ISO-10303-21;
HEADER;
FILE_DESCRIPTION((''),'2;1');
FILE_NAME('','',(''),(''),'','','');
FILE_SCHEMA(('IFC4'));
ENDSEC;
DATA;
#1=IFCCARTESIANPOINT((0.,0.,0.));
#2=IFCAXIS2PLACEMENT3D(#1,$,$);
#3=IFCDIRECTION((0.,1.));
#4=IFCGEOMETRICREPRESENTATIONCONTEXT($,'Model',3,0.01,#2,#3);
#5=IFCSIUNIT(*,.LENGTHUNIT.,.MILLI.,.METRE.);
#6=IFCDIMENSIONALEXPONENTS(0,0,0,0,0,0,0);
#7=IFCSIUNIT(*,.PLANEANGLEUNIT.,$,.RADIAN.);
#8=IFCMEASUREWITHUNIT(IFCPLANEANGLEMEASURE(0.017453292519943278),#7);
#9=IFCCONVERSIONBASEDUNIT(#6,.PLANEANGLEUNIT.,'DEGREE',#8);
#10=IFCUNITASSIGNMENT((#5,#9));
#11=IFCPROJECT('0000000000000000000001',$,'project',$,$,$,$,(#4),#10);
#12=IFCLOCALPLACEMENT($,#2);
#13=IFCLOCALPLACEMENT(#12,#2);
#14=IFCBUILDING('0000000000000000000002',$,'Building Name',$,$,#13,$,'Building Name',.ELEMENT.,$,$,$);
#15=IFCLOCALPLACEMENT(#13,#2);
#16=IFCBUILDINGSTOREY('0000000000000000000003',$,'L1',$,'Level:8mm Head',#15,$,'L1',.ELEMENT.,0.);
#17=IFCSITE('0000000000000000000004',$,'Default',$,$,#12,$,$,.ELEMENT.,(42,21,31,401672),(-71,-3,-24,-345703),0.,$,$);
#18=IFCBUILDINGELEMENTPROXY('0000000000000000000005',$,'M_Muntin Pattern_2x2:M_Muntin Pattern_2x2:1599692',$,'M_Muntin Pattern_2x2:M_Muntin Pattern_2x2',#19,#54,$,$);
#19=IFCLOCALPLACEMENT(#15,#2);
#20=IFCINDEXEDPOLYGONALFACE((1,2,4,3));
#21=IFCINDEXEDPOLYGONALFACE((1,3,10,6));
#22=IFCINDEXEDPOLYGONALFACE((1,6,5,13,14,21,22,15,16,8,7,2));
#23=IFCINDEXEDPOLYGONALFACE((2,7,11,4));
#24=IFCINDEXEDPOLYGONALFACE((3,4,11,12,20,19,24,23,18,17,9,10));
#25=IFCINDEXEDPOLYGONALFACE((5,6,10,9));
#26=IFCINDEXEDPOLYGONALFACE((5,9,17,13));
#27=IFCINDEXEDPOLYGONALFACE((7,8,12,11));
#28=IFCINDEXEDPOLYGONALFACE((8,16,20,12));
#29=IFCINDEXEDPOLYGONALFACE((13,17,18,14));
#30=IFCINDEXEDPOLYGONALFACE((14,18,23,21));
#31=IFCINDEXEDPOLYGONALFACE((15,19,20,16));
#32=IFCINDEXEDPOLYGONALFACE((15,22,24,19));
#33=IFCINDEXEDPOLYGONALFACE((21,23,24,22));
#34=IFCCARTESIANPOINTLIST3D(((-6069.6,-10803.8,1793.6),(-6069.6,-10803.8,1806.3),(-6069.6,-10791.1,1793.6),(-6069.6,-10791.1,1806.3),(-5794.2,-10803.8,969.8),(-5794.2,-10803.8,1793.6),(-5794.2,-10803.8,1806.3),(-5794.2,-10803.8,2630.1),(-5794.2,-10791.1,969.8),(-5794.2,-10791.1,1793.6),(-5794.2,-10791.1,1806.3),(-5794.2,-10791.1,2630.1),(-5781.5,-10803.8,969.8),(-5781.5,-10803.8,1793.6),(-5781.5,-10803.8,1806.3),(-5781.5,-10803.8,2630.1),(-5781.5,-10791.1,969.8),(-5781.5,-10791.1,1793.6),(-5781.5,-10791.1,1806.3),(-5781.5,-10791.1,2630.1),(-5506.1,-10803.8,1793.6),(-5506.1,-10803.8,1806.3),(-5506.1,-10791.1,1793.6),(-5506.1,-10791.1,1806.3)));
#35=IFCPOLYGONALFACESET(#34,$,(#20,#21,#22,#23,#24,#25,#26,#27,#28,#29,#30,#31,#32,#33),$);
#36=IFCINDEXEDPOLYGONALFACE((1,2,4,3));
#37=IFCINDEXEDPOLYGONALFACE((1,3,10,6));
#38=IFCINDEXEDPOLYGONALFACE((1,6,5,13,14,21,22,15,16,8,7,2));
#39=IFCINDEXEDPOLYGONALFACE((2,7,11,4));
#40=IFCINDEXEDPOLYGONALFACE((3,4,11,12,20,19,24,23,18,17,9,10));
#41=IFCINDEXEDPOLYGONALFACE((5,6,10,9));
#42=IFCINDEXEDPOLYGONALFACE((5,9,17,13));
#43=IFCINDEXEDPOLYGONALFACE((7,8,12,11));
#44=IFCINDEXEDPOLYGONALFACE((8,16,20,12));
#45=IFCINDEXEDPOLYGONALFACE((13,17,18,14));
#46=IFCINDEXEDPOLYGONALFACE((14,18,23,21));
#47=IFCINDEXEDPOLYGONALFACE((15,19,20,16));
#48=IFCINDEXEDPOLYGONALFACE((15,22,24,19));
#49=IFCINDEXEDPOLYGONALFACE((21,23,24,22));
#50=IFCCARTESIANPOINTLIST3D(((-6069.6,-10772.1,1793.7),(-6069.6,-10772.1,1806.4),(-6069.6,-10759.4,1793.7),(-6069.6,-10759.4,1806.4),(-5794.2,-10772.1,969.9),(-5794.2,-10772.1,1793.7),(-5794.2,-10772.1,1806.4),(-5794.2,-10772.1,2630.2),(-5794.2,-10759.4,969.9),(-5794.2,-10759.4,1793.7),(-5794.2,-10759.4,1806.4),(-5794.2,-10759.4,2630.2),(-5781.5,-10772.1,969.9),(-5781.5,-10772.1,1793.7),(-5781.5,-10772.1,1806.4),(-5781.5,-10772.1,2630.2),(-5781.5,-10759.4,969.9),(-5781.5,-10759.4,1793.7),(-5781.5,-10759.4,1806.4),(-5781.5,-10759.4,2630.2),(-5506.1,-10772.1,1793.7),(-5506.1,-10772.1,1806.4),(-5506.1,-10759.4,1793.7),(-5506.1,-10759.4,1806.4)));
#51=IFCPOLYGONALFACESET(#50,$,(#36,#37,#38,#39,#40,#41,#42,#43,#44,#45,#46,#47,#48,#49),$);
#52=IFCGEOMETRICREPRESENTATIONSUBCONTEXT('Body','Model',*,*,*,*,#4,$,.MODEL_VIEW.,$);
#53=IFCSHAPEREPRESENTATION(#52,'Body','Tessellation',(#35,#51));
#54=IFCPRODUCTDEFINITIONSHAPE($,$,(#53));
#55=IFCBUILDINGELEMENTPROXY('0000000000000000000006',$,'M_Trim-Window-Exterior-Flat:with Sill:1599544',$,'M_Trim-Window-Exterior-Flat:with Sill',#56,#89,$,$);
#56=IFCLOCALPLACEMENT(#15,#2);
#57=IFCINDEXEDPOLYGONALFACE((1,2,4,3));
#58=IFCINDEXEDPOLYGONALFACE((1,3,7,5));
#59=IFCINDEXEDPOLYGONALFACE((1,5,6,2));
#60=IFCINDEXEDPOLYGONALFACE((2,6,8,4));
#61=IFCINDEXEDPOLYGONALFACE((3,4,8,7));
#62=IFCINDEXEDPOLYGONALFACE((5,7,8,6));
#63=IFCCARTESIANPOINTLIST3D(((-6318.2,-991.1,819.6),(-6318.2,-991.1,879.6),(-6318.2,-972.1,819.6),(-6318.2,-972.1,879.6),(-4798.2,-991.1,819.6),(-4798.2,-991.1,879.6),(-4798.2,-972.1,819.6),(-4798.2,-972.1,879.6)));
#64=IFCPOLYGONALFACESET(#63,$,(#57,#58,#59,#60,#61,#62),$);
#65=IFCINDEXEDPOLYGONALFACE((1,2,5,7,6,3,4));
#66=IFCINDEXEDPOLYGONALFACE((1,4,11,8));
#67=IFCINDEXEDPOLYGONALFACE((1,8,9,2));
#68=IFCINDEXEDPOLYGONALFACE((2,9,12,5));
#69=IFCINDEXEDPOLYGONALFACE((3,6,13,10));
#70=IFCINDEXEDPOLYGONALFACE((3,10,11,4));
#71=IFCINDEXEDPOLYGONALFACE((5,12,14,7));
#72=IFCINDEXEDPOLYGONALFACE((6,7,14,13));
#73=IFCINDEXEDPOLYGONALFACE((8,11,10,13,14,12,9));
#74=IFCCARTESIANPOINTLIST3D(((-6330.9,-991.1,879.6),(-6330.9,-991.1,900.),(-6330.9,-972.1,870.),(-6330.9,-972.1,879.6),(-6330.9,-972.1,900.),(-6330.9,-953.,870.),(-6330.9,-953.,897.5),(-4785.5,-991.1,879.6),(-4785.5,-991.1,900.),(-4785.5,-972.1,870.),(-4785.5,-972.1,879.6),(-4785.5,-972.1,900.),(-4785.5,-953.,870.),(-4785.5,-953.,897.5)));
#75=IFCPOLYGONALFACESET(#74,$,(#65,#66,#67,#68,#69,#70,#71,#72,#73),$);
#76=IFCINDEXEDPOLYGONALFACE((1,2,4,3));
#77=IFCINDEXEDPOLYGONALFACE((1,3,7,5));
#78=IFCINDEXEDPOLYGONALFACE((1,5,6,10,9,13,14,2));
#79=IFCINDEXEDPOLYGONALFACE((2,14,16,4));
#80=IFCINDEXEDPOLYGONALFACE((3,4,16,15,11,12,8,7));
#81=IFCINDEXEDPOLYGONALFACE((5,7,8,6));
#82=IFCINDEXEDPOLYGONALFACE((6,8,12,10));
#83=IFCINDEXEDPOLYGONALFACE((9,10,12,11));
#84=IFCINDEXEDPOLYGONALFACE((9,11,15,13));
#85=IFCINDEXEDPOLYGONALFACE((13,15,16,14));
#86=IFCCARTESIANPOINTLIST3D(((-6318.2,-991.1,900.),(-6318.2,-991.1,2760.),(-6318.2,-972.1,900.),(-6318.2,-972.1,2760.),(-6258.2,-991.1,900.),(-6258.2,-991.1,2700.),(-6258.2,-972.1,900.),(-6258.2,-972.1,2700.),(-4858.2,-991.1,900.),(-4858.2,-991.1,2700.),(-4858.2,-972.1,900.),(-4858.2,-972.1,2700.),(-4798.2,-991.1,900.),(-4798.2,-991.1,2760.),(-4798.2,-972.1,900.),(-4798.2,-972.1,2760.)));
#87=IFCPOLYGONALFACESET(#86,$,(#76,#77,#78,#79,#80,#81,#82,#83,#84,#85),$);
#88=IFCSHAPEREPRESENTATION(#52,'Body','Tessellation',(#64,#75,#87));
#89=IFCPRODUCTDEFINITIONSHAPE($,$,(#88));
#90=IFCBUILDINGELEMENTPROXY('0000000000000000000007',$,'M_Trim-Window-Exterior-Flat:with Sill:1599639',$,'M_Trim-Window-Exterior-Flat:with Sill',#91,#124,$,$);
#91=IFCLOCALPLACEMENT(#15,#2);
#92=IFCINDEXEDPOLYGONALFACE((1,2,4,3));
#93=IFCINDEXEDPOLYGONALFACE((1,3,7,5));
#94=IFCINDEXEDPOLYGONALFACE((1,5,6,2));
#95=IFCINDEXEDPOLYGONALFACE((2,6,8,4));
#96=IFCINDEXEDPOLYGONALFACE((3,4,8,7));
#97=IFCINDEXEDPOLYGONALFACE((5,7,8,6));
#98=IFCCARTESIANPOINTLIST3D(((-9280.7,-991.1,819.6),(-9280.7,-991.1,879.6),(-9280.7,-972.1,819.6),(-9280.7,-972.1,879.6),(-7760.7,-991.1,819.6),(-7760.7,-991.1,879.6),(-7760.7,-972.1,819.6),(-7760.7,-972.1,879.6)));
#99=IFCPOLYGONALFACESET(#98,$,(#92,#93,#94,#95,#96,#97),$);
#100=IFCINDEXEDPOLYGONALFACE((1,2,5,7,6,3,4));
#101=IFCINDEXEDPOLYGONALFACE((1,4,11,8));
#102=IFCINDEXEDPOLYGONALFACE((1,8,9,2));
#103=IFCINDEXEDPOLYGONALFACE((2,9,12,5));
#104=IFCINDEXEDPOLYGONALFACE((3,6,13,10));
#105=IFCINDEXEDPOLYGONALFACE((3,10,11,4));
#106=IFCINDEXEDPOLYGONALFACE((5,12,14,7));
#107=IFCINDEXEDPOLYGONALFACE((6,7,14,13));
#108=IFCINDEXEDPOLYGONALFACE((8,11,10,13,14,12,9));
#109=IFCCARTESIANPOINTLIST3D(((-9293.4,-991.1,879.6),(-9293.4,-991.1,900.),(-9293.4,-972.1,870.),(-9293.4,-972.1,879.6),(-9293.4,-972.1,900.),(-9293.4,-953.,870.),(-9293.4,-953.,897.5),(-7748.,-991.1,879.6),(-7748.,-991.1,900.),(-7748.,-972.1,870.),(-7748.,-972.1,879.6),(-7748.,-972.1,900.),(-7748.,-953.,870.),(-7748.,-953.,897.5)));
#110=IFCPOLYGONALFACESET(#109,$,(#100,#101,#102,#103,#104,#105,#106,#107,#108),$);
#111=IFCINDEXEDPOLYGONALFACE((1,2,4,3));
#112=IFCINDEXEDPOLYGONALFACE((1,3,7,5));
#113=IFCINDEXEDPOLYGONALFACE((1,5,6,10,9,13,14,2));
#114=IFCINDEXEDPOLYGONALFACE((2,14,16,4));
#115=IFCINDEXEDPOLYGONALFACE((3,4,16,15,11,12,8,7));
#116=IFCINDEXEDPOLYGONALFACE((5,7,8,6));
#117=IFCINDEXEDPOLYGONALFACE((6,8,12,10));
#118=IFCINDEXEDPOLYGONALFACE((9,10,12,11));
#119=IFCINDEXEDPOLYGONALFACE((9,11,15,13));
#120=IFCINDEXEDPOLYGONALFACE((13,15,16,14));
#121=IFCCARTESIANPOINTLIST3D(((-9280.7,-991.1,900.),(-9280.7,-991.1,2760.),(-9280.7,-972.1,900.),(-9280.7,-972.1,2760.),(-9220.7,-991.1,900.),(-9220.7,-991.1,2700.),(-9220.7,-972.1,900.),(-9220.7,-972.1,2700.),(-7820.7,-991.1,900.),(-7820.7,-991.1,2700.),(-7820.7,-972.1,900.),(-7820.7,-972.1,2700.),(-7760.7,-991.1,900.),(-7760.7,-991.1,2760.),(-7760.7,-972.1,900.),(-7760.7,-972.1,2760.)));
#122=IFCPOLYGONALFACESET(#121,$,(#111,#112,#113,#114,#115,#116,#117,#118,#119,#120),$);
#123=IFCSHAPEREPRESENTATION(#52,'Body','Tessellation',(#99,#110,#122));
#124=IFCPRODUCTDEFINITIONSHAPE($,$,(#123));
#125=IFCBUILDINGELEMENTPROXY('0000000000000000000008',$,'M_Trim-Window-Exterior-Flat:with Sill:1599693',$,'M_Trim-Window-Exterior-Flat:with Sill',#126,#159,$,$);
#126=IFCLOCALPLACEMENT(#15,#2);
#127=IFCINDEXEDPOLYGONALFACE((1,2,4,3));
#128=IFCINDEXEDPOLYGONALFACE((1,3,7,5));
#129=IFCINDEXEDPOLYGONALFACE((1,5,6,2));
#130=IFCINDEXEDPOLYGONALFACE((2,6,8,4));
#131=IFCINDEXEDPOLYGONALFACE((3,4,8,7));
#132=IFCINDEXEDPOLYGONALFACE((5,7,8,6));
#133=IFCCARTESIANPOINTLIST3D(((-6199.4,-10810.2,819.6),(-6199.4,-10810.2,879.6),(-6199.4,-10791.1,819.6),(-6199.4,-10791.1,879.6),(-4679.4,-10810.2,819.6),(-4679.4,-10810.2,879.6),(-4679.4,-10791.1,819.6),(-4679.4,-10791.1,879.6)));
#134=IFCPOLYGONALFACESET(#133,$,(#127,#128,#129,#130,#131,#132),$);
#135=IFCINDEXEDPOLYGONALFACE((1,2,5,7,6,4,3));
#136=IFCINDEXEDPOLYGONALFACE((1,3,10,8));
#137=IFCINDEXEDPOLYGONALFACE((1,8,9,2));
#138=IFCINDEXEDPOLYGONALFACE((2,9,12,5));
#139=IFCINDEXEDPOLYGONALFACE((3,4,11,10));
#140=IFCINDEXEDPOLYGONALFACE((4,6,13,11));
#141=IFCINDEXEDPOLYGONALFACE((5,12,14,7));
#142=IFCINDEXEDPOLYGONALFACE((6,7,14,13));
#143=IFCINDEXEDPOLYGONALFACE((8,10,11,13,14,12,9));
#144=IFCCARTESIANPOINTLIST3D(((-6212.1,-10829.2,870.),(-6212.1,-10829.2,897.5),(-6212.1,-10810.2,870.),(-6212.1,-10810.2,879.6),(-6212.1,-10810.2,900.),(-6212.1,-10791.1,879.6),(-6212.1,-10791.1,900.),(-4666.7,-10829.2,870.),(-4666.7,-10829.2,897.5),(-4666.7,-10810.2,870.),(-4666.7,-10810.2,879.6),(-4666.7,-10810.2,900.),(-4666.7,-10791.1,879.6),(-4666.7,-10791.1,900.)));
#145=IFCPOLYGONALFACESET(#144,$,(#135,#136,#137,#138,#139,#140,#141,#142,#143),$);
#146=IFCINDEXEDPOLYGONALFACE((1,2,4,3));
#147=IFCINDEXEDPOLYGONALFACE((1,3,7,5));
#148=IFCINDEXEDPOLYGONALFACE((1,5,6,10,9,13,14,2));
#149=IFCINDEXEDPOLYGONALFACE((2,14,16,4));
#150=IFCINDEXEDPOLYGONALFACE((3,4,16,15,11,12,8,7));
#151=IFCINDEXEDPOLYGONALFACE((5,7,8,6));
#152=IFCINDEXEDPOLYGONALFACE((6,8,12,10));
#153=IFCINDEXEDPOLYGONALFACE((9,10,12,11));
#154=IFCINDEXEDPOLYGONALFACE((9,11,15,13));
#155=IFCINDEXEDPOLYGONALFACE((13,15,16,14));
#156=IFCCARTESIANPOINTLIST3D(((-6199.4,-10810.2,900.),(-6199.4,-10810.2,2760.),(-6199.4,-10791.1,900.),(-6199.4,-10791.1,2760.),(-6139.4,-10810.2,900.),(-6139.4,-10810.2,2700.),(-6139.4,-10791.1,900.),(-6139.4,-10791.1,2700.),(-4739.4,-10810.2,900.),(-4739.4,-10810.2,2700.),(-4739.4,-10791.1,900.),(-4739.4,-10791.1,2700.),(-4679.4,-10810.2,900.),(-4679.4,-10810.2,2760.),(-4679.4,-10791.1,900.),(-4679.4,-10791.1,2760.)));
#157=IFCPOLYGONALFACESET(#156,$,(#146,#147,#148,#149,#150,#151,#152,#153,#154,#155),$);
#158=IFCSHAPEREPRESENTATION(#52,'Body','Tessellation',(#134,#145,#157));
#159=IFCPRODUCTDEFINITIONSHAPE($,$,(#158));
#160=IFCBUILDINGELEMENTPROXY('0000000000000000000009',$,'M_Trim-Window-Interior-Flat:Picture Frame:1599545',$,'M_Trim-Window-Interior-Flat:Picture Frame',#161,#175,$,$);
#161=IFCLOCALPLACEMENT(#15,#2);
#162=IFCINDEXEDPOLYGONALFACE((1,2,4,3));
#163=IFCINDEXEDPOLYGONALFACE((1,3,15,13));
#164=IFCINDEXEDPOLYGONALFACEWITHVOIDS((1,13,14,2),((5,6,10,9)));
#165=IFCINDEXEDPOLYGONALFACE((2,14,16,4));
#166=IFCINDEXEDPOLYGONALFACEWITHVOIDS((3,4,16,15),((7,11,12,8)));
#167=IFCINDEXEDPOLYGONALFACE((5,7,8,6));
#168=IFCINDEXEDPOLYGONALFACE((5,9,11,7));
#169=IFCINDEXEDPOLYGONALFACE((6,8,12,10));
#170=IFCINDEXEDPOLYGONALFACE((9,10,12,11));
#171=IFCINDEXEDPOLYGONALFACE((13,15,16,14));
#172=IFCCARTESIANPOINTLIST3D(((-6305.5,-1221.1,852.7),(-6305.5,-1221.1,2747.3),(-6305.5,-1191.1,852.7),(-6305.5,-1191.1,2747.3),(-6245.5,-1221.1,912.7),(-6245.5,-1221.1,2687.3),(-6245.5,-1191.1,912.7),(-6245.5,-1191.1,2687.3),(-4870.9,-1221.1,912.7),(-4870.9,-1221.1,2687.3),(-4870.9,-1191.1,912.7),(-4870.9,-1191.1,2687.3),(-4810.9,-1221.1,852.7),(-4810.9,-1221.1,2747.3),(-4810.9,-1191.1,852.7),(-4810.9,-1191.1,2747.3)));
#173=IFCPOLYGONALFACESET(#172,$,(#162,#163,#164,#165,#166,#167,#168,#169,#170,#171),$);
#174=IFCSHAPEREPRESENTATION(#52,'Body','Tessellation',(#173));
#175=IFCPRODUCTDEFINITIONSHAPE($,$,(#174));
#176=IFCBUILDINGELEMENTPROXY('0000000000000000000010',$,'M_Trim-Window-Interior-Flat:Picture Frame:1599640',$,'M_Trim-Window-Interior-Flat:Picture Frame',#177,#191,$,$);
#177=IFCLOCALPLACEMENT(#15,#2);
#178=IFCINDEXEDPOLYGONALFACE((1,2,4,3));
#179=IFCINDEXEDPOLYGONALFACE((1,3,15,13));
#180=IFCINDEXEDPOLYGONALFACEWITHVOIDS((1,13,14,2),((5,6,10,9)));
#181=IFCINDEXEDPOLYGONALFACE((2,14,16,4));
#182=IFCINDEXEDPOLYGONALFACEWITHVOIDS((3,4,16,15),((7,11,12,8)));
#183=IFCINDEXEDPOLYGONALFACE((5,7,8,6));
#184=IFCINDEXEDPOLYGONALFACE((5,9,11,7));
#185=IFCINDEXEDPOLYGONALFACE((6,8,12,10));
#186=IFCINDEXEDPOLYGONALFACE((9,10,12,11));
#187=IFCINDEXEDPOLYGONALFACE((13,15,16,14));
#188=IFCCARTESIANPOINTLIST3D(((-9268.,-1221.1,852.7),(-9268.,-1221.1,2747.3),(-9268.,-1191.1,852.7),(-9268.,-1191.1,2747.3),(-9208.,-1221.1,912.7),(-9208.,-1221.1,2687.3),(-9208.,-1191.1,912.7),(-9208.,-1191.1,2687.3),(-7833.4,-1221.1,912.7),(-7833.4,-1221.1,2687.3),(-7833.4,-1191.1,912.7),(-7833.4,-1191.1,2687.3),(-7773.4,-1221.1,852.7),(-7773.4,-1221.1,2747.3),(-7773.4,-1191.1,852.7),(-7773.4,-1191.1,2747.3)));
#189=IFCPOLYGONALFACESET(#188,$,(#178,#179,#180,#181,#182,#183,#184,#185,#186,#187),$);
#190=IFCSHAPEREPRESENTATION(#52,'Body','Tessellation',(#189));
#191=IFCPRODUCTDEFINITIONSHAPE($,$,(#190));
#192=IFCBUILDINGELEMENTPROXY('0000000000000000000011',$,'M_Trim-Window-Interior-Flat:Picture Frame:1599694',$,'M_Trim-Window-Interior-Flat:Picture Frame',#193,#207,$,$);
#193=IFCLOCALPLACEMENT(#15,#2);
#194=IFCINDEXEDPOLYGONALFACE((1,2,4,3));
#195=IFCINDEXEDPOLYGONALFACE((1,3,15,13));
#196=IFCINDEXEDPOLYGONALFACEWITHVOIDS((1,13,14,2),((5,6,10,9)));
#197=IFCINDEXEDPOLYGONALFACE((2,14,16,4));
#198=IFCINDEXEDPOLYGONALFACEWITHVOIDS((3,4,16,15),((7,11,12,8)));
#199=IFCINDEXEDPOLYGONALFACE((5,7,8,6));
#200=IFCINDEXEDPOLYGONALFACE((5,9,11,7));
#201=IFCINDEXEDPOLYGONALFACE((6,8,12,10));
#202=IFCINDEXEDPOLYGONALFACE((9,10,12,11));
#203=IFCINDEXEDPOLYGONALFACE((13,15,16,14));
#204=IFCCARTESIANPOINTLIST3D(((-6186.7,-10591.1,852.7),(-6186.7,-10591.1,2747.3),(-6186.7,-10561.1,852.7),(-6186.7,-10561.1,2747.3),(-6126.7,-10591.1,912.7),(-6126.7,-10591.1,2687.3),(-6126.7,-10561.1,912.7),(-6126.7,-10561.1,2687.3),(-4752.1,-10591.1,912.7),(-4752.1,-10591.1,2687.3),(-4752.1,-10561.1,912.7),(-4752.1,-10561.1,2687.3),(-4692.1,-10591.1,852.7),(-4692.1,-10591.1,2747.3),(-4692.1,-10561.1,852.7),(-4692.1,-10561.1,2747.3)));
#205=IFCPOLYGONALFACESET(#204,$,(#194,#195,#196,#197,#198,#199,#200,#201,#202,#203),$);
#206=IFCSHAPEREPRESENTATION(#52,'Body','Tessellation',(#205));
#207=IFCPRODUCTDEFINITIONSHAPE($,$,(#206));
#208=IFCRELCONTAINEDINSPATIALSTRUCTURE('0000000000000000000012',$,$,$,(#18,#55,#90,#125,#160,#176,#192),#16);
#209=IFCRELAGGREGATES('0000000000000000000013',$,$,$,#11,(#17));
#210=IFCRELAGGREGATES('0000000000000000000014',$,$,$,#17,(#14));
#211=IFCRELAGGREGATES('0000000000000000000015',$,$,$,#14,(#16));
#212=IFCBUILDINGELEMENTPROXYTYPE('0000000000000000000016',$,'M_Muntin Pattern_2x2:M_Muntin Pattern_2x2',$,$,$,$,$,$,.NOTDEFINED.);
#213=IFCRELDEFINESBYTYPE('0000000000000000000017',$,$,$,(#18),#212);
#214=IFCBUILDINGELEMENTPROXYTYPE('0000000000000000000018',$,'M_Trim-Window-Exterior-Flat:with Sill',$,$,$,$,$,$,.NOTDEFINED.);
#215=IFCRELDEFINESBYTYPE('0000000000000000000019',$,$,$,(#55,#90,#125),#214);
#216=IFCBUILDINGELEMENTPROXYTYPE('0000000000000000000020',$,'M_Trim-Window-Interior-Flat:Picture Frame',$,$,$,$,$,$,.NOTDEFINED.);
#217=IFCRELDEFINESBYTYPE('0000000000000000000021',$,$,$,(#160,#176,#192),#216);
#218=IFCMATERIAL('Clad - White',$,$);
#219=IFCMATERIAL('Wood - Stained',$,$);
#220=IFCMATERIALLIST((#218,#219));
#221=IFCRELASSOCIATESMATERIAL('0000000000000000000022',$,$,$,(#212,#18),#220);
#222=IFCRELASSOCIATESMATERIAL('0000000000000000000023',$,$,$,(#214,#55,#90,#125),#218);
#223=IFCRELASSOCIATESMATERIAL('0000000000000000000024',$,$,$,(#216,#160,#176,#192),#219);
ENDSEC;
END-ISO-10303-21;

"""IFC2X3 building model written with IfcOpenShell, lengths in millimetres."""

from ifc_helpers import new_model, entity, si_unit, converted_unit, direction, frame, frame_2d, origin, place, context, subcontext, project, spatial, polyline, rectangle, outline, extrude, source, transform, mapped, material, material_list, type_object, type_shapes, element, save


model = new_model("IFC2X3")

# Units and contexts
model_context = context("Model", 3, precision=0.01, world=origin(), true_north=direction((0.0, 1.0)))
body_context = subcontext(model_context, "Body", "Model", "MODEL_VIEW")
ifc_project = project(units=[si_unit("LENGTHUNIT", "METRE", prefix="MILLI"), converted_unit("PLANEANGLEUNIT", "DEGREE", entity("IfcPlaneAngleMeasure", 0.017453292519943278), si_unit("PLANEANGLEUNIT", "RADIAN"), dimensions=[0, 0, 0, 0, 0, 0, 0])], contexts=[model_context])

# Site, building, storey
site_placement = place(None, origin())
site = spatial("IfcSite", under=ifc_project, at=site_placement, Name="Default", CompositionType="ELEMENT", RefLatitude=(42, 21, 31, 401672), RefLongitude=(-71, -3, -24, -345703), RefElevation=0.0)
building_placement = place(site_placement, origin())
building = spatial("IfcBuilding", under=site, at=building_placement, Name="Building Name", LongName="Building Name", CompositionType="ELEMENT")
storey_placement = place(building_placement, origin())
storey = spatial("IfcBuildingStorey", under=building, at=storey_placement, Name="L1", ObjectType="Level:8mm Head", LongName="L1", CompositionType="ELEMENT", Elevation=0.0)

# Building element proxies
ifc_material_1 = material(Name="Clad - White")
ifc_material_2 = material(Name="Wood - Stained")
ifc_material_list = material_list([ifc_material_1, ifc_material_2])
building_element_proxy_type_1 = type_object("IfcBuildingElementProxyType", Name="M_Muntin Pattern_2x2:M_Muntin Pattern_2x2", PredefinedType="NOTDEFINED", material=ifc_material_list)
shared_shape_1 = source(origin(), body_context, "Body", "SweptSolid", [
    extrude(outline(polyline([(6.4, -6.4), (830.1, -6.4), (830.1, 6.3), (6.4, 6.3), (6.4, 281.7), (-6.3, 281.7), (-6.3, 6.3), (-830.2, 6.3), (-830.2, -6.4), (-6.3, -6.4), (-6.3, -281.7), (6.4, -281.7), (6.4, -6.4)])), frame((0.0, -22.2, 830.1), z_axis=(0.0, 1.0, 0.0), x_axis=(0.0, 0.0, 1.0)), (0.0, 0.0, 1.0), 12.7),
    extrude(outline(polyline([(6.4, -6.4), (830.2, -6.4), (830.2, 6.3), (6.4, 6.3), (6.4, 281.7), (-6.3, 281.7), (-6.3, 6.3), (-830.2, 6.3), (-830.2, -6.4), (-6.3, -6.4), (-6.3, -281.7), (6.4, -281.7), (6.4, -6.4)])), frame((0.0, 9.5, 830.2), z_axis=(0.0, 1.0, 0.0), x_axis=(0.0, 0.0, 1.0)), (0.0, 0.0, 1.0), 12.7),
])
type_shapes(building_element_proxy_type_1, [shared_shape_1])
proxy_1_placement = place(storey_placement, frame((-5787.9, -10781.6, 969.9)))
element("IfcBuildingElementProxy", 1, at=proxy_1_placement, inside=storey, type_object=building_element_proxy_type_1, material=ifc_material_list, Name="M_Muntin Pattern_2x2:M_Muntin Pattern_2x2:1599692", ObjectType="M_Muntin Pattern_2x2:M_Muntin Pattern_2x2", context=body_context, shape_type="MappedRepresentation", body=[
    mapped(shared_shape_1, transform((0.0, 0.0, 0.0), scale=1.0)),
])
building_element_proxy_type_2 = type_object("IfcBuildingElementProxyType", Name="M_Trim-Window-Exterior-Flat:with Sill", PredefinedType="NOTDEFINED", material=ifc_material_1)
shared_shape_2 = source(origin(), body_context, "Body", "SweptSolid", [
    extrude(rectangle(XDim=1520.0, YDim=60.0, at=frame_2d((0.0, 0.0), x_axis=(1.0, 0.0))), frame((0.0, -1850.4, 0.0), z_axis=(0.0, 0.0, 1.0), x_axis=(-1.0, 0.0, 0.0)), (0.0, 0.0, 1.0), 19.0),
    extrude(outline(polyline([(-19.0, -15.2), (0.0, -15.2), (0.0, -5.7), (19.0, -5.7), (19.0, 14.8), (0.0, 14.8), (-19.0, 12.3), (-19.0, -15.2)])), frame((-772.7, -1814.8, 19.0), z_axis=(1.0, 0.0, 0.0), x_axis=(0.0, 0.0, -1.0)), (0.0, 0.0, 1.0), 1545.4),
    extrude(outline(polyline([(-945.0, -760.0), (915.0, -760.0), (915.0, -700.0), (-885.0, -700.0), (-885.0, 700.0), (915.0, 700.0), (915.0, 760.0), (-945.0, 760.0), (-945.0, -760.0)])), frame((0.0, -885.0, 0.0), z_axis=(0.0, 0.0, 1.0), x_axis=(0.0, -1.0, 0.0)), (0.0, 0.0, 1.0), 19.0),
])
type_shapes(building_element_proxy_type_2, [shared_shape_2])
for number, where, z_axis, x_axis, name in (
    (2, (-5558.2, -991.1, 2700.0), (0.0, 1.0, 0.0), (-1.0, 0.0, 0.0), "M_Trim-Window-Exterior-Flat:with Sill:1599544"),
    (3, (-8520.7, -991.1, 2700.0), (0.0, 1.0, 0.0), (-1.0, 0.0, 0.0), "M_Trim-Window-Exterior-Flat:with Sill:1599639"),
    (4, (-5439.4, -10791.1, 2700.0), (0.0, -1.0, 0.0), (1.0, 0.0, 0.0), "M_Trim-Window-Exterior-Flat:with Sill:1599693"),
):
    element("IfcBuildingElementProxy", number, at=place(storey_placement, frame(where, z_axis=z_axis, x_axis=x_axis)), inside=storey, type_object=building_element_proxy_type_2, material=ifc_material_1, Name=name, ObjectType="M_Trim-Window-Exterior-Flat:with Sill", context=body_context, shape_type="MappedRepresentation", body=[
        mapped(shared_shape_2, transform((0.0, 0.0, 0.0), scale=1.0)),
    ])
building_element_proxy_type_3 = type_object("IfcBuildingElementProxyType", Name="M_Trim-Window-Interior-Flat:Picture Frame", PredefinedType="NOTDEFINED", material=ifc_material_2)
shared_shape_3 = source(origin(), body_context, "Body", "SweptSolid", [
    extrude(outline(polyline([(-747.3, -947.3), (747.3, -947.3), (747.3, 947.3), (-747.3, 947.3), (-747.3, -947.3)]), holes=[polyline([(-687.3, -887.3), (-687.3, 887.3), (687.3, 887.3), (687.3, -887.3), (-687.3, -887.3)])]), frame((0.0, -900.0, 0.0), z_axis=(0.0, 0.0, 1.0), x_axis=(-1.0, 0.0, 0.0)), (0.0, 0.0, 1.0), 30.0),
])
type_shapes(building_element_proxy_type_3, [shared_shape_3])
for number, where, z_axis, x_axis, name in (
    (5, (-5558.2, -1191.1, 2700.0), (0.0, -1.0, 0.0), (1.0, 0.0, 0.0), "M_Trim-Window-Interior-Flat:Picture Frame:1599545"),
    (6, (-8520.7, -1191.1, 2700.0), (0.0, -1.0, 0.0), (1.0, 0.0, 0.0), "M_Trim-Window-Interior-Flat:Picture Frame:1599640"),
    (7, (-5439.4, -10591.1, 2700.0), (0.0, 1.0, 0.0), (-1.0, 0.0, 0.0), "M_Trim-Window-Interior-Flat:Picture Frame:1599694"),
):
    element("IfcBuildingElementProxy", number, at=place(storey_placement, frame(where, z_axis=z_axis, x_axis=x_axis)), inside=storey, type_object=building_element_proxy_type_3, material=ifc_material_2, Name=name, ObjectType="M_Trim-Window-Interior-Flat:Picture Frame", context=body_context, shape_type="MappedRepresentation", body=[
        mapped(shared_shape_3, transform((0.0, 0.0, 0.0), scale=1.0)),
    ])

save(model, "model.ifc")
